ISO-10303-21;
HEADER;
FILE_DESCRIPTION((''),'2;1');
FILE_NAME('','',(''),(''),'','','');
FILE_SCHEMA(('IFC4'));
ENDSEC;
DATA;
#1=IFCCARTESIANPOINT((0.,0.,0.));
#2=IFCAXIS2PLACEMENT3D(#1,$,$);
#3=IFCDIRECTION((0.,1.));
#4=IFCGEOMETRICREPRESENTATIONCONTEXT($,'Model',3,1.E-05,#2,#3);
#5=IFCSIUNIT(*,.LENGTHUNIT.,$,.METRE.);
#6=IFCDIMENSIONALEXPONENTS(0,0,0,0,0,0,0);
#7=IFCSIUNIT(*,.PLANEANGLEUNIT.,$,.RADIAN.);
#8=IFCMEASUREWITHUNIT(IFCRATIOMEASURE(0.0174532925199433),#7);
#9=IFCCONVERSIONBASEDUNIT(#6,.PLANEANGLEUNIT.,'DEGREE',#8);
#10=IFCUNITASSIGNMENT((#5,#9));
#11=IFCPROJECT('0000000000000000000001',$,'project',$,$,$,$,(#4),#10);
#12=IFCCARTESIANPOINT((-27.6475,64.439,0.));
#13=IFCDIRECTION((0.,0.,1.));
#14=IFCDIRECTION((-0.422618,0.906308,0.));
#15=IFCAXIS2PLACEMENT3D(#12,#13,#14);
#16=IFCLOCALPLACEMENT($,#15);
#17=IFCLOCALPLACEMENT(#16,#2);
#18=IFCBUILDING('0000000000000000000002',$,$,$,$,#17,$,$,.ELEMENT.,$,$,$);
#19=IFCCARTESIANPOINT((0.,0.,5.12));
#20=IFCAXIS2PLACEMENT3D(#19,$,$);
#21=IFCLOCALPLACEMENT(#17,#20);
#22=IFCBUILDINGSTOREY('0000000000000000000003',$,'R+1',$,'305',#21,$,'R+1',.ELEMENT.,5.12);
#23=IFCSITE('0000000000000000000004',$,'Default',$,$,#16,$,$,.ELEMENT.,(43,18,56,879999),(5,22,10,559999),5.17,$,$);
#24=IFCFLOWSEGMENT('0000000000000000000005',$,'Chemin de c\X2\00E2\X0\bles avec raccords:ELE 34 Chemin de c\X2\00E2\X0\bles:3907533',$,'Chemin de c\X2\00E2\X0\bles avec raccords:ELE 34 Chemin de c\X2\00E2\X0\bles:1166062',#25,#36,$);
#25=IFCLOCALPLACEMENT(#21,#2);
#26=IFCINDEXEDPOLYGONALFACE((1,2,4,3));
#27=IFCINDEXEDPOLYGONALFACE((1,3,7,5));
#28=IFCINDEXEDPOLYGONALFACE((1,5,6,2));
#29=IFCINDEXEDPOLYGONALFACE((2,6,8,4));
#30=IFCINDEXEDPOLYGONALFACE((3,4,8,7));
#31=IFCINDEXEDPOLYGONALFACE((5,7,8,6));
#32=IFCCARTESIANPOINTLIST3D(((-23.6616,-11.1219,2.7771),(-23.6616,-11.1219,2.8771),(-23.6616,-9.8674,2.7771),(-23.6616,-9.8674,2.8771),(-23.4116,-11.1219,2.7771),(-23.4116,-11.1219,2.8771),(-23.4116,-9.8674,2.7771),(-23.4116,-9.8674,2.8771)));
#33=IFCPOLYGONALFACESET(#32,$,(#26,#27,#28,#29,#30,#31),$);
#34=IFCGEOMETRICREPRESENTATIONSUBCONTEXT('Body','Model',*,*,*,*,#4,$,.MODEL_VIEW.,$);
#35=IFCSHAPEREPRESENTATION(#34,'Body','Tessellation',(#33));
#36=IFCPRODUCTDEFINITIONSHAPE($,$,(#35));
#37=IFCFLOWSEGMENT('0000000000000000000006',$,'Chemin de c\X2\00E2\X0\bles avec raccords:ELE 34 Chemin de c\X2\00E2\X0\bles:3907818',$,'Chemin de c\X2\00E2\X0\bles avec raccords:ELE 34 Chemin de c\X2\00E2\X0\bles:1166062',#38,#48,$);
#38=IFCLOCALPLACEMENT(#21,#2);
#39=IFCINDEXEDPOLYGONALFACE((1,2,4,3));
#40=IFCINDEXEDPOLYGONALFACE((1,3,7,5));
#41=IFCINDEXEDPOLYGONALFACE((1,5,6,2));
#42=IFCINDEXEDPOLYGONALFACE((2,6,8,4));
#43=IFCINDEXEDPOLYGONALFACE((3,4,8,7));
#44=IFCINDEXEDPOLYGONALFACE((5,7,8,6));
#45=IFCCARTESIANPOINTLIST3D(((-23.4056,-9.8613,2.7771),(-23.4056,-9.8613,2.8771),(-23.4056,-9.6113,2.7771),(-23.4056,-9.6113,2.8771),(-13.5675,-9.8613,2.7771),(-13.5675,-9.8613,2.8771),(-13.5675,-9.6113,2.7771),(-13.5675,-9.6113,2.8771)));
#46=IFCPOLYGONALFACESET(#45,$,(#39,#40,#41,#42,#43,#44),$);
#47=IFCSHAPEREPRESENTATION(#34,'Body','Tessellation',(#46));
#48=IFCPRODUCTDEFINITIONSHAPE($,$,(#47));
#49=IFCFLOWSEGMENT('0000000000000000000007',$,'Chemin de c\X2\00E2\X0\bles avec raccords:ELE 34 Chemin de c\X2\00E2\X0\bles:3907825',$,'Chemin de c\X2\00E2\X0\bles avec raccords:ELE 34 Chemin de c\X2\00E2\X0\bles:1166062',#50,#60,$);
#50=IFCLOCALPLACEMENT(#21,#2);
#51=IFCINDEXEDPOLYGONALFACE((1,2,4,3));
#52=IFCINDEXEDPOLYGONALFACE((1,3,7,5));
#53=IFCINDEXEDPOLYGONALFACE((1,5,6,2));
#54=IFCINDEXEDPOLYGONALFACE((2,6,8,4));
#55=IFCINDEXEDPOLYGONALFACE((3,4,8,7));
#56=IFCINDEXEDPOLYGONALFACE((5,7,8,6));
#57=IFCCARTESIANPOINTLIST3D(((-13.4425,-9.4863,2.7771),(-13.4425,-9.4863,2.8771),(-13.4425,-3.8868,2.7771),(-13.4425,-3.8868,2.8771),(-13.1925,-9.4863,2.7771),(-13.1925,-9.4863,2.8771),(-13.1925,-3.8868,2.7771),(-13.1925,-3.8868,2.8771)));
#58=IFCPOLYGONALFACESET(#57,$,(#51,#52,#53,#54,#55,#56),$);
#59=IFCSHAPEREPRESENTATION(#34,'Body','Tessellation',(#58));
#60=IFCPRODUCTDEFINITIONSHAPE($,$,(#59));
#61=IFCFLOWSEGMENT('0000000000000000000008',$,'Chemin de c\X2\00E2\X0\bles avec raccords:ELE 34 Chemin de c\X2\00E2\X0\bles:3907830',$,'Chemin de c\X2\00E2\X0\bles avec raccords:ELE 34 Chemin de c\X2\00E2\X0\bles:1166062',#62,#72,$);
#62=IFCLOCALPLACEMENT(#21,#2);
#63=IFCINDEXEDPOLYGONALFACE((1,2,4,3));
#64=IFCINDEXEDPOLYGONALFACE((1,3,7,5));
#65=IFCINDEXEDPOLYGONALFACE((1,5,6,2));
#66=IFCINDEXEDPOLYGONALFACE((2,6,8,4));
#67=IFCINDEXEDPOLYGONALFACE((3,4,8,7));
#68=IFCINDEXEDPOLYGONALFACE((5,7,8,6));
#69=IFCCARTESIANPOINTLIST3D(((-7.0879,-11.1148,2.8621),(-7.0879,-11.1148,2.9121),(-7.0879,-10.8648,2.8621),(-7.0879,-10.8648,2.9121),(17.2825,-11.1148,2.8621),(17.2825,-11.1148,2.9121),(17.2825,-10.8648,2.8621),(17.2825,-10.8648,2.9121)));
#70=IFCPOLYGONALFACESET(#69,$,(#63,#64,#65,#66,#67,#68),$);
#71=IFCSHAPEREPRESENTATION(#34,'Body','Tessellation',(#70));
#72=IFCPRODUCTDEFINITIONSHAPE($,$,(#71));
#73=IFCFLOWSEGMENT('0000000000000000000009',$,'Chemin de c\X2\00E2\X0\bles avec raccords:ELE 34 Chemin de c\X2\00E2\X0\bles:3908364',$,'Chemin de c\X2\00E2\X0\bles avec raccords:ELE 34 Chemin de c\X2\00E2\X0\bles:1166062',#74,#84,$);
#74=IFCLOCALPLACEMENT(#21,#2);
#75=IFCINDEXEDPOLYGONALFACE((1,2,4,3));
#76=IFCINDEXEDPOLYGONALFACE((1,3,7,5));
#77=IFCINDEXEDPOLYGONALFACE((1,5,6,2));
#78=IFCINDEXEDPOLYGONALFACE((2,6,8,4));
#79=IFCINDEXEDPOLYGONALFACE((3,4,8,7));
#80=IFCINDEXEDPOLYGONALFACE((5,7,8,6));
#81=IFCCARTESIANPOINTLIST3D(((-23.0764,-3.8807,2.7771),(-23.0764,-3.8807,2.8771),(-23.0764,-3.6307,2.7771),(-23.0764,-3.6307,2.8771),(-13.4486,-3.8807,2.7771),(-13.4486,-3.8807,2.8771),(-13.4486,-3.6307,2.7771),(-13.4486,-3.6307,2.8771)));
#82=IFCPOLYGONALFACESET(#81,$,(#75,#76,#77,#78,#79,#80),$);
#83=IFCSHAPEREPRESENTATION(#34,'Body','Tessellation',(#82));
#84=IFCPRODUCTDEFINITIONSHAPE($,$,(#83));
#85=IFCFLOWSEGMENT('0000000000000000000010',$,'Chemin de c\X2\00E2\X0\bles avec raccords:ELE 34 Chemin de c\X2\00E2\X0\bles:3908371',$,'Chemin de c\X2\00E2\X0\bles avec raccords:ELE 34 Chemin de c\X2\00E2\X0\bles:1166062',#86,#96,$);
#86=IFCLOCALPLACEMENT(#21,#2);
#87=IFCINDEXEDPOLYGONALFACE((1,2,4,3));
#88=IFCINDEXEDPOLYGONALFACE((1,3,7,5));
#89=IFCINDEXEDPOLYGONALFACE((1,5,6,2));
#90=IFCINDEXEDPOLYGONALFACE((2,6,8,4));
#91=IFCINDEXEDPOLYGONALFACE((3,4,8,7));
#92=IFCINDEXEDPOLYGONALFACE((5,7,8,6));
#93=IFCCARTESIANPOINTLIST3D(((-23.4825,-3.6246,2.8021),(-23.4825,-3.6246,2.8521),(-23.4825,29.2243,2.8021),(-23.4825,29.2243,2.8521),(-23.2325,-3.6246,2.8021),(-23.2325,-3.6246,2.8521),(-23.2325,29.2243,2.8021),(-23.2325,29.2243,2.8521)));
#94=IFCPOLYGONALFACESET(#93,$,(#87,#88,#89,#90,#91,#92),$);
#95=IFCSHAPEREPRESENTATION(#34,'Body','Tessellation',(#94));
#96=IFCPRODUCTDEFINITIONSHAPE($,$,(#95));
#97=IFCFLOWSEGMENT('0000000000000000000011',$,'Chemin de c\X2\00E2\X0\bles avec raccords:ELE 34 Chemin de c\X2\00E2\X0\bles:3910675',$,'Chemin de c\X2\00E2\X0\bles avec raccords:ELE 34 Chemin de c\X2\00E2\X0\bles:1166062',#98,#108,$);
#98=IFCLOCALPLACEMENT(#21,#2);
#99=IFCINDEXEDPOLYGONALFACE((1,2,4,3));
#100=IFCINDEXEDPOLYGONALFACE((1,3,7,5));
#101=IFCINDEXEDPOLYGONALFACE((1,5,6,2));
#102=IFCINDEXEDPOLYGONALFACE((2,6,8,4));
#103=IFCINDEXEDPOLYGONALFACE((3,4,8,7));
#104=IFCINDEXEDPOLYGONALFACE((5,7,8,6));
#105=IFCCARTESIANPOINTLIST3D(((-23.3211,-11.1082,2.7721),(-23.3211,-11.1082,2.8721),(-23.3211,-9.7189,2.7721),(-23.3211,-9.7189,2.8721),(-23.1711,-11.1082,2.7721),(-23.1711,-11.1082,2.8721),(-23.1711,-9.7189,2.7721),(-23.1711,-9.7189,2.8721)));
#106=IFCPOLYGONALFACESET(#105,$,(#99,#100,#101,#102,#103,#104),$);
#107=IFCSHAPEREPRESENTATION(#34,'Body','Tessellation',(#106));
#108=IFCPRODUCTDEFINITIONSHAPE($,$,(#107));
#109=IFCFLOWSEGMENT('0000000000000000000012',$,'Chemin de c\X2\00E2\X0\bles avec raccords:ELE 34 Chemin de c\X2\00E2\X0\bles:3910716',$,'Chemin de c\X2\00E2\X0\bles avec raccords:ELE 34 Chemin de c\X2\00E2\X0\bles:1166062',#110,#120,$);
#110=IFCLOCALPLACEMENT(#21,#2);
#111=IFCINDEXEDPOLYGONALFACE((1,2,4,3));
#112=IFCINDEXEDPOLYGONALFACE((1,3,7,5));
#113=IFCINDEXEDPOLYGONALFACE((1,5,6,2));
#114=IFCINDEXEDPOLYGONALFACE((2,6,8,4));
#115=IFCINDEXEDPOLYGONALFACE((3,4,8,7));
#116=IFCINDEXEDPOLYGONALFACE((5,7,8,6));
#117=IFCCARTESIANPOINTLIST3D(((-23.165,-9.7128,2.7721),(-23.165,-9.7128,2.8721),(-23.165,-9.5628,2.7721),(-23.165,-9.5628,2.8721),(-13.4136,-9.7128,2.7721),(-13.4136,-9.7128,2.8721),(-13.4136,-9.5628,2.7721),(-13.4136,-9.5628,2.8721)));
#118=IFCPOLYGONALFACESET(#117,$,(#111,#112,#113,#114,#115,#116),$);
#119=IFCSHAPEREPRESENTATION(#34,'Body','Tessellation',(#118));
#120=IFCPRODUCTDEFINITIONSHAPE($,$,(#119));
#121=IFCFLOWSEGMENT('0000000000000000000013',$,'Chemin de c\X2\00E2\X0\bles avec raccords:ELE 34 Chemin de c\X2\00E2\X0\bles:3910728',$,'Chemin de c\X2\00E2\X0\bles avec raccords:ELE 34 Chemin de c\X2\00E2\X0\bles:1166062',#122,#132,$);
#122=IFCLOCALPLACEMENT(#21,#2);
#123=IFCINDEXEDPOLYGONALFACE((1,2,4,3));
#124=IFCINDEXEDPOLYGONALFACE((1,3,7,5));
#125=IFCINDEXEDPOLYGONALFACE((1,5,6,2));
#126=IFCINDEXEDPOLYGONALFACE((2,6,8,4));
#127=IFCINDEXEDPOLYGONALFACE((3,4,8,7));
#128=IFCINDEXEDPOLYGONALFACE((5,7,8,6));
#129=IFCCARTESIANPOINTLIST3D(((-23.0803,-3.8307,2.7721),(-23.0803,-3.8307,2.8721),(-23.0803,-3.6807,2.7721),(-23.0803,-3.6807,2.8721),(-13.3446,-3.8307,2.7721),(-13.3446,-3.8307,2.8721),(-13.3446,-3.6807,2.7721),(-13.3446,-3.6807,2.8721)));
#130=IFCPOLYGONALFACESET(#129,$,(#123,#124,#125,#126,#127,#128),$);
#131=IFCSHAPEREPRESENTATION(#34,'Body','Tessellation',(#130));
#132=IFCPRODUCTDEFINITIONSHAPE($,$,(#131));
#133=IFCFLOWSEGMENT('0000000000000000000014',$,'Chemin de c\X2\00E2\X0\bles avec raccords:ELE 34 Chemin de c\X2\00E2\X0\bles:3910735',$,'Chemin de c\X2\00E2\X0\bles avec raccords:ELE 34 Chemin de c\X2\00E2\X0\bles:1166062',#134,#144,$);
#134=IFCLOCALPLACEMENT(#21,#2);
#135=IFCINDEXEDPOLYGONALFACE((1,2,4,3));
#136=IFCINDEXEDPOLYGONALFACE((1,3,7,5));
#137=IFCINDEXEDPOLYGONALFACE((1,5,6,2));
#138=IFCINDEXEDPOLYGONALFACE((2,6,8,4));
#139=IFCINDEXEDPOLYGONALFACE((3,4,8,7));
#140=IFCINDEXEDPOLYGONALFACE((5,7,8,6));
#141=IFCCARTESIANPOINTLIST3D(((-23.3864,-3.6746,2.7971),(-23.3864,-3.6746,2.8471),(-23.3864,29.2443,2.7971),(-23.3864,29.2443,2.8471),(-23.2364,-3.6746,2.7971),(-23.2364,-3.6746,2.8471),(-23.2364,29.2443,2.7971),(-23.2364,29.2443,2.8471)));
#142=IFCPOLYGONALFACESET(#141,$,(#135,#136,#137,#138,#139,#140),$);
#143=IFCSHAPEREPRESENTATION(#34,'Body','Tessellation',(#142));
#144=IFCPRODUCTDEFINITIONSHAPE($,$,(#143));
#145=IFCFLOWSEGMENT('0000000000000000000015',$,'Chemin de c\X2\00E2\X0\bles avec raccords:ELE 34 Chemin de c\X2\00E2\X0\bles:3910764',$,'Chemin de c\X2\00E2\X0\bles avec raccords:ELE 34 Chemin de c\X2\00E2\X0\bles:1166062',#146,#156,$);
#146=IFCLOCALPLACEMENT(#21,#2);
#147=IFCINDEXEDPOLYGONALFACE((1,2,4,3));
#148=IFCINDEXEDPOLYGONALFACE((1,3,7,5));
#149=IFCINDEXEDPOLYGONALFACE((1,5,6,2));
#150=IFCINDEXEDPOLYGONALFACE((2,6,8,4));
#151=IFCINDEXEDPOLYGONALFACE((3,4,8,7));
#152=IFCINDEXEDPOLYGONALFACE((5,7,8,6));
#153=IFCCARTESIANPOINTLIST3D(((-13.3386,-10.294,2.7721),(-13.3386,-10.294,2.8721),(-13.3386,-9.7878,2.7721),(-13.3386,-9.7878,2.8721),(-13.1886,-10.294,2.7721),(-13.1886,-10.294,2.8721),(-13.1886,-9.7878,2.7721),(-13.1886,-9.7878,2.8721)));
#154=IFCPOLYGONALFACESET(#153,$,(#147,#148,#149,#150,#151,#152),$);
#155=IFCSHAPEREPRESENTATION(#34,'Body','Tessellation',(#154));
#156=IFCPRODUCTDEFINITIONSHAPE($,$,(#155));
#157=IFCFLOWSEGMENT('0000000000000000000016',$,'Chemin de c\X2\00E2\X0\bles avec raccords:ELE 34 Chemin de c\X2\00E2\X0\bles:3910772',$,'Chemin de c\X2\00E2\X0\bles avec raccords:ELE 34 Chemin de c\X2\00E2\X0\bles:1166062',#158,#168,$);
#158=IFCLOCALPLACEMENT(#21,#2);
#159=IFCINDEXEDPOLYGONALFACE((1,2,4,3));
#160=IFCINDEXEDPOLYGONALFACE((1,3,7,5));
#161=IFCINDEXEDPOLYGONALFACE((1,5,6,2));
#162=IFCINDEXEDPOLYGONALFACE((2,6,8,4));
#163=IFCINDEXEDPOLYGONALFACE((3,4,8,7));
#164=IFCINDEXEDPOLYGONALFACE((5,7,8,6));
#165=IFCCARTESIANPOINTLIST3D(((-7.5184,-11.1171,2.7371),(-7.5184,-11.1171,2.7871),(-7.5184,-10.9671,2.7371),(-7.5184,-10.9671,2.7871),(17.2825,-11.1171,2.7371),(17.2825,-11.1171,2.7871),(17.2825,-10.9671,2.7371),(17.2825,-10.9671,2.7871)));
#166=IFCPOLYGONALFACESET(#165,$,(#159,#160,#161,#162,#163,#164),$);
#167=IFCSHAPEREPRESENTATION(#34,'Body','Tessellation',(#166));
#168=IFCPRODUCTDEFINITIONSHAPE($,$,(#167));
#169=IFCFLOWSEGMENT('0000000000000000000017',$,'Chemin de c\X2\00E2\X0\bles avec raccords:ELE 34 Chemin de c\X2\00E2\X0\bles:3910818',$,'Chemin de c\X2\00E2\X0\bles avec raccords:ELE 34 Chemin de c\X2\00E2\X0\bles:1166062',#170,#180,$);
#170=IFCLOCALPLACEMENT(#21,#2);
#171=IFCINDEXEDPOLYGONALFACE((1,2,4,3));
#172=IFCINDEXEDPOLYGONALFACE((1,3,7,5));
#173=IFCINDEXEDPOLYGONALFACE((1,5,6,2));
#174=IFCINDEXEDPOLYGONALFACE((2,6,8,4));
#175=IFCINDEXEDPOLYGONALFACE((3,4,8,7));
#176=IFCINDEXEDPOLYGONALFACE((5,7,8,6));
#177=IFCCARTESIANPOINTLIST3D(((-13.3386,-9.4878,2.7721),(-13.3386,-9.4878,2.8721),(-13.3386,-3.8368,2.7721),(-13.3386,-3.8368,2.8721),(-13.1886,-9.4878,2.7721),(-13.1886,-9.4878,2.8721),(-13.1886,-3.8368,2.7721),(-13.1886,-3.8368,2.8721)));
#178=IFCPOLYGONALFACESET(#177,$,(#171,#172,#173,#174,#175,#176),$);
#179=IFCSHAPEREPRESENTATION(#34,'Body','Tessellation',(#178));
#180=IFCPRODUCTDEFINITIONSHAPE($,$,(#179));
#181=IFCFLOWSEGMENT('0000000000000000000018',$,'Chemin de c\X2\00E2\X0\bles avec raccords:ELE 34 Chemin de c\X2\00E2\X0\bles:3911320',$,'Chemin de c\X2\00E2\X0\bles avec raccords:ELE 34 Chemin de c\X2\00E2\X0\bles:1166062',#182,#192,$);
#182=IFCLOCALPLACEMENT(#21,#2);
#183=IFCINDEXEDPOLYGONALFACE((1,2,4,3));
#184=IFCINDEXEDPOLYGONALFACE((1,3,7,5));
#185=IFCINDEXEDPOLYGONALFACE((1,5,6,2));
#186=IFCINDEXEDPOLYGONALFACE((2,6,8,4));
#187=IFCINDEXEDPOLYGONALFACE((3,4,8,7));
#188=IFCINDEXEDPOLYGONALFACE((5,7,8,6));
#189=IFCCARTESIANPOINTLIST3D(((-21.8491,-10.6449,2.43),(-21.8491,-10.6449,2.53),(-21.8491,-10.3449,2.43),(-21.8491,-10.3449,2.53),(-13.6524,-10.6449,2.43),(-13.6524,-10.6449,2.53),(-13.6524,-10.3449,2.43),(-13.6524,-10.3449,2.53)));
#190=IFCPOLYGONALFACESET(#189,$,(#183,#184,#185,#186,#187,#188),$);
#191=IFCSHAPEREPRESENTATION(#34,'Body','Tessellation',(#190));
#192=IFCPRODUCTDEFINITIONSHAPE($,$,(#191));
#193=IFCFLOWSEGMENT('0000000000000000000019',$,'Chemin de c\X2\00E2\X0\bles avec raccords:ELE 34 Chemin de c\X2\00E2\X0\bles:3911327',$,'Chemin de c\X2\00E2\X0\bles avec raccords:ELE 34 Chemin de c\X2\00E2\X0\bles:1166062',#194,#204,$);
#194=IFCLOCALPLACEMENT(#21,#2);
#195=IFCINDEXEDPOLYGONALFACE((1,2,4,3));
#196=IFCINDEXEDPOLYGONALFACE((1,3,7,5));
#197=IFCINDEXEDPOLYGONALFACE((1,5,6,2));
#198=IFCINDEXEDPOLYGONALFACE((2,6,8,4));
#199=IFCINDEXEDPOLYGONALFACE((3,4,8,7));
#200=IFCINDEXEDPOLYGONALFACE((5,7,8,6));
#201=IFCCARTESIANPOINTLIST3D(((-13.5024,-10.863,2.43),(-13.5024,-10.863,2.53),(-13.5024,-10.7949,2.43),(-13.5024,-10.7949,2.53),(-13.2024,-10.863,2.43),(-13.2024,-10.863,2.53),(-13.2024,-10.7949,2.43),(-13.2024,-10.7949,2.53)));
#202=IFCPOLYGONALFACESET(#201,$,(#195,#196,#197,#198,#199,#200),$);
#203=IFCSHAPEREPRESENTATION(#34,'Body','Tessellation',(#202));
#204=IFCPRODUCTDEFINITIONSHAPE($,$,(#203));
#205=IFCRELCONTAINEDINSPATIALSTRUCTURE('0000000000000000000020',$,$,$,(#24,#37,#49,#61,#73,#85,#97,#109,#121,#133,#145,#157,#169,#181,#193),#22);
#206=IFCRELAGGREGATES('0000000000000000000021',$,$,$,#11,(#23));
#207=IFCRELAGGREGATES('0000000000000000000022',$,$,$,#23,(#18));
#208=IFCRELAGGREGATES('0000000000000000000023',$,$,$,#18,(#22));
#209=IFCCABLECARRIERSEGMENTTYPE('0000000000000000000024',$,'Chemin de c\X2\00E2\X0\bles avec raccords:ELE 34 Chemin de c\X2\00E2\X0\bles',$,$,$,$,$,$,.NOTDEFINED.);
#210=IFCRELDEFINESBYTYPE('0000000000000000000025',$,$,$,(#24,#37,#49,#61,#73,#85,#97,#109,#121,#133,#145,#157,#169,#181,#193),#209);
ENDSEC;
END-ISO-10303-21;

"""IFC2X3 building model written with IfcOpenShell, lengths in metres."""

from ifc_helpers import new_model, entity, si_unit, converted_unit, direction, frame, frame_2d, origin, origin_2d_with_axis, place, context, subcontext, project, spatial, polyline, rectangle, outline, extrude, type_object, element, save


model = new_model("IFC2X3")

# Units and contexts
model_context = context("Model", 3, precision=1e-05, world=origin(), true_north=direction((0.0, 1.0)))
body_context = subcontext(model_context, "Body", "Model", "MODEL_VIEW")
ifc_project = project(units=[si_unit("LENGTHUNIT", "METRE"), converted_unit("PLANEANGLEUNIT", "DEGREE", entity("IfcRatioMeasure", 0.0174532925199433), si_unit("PLANEANGLEUNIT", "RADIAN"), dimensions=[0, 0, 0, 0, 0, 0, 0])], contexts=[model_context])

# Site, building, storey
site_placement = place(None, frame((-27.6475, 64.439, 0.0), z_axis=(0.0, 0.0, 1.0), x_axis=(-0.422618, 0.906308, 0.0)))
site = spatial("IfcSite", under=ifc_project, at=site_placement, Name="Default", CompositionType="ELEMENT", RefLatitude=(43, 18, 56, 879999), RefLongitude=(5, 22, 10, 559999), RefElevation=5.17)
building_placement = place(site_placement, origin())
building = spatial("IfcBuilding", under=site, at=building_placement, CompositionType="ELEMENT")
storey_placement = place(building_placement, frame((0.0, 0.0, 5.12)))
storey = spatial("IfcBuildingStorey", under=building, at=storey_placement, Name="R+1", ObjectType="305", LongName="R+1", CompositionType="ELEMENT", Elevation=5.12)

# Flow segments
cable_carrier_segment_type = type_object("IfcCableCarrierSegmentType", Name="Chemin de câbles avec raccords:ELE 34 Chemin de câbles", PredefinedType="NOTDEFINED")
flow_segment_1_placement = place(storey_placement, origin())
element("IfcFlowSegment", 1, at=flow_segment_1_placement, inside=storey, type_object=cable_carrier_segment_type, Name="Chemin de câbles avec raccords:ELE 34 Chemin de câbles:3907533", ObjectType="Chemin de câbles avec raccords:ELE 34 Chemin de câbles:1166062", context=body_context, shape_type="SweptSolid", body=[
    extrude(outline(polyline([(-0.6273, -0.125), (0.6273, -0.125), (0.6273, 0.125), (-0.6273, 0.125), (-0.6273, -0.125)])), frame((-23.5366, -10.4947, 2.7771), z_axis=(0.0, 0.0, 1.0), x_axis=(0.0, -1.0, 0.0)), (0.0, 0.0, 1.0), 0.1),
])
flow_segment_2_placement = place(storey_placement, origin())
element("IfcFlowSegment", 2, at=flow_segment_2_placement, inside=storey, type_object=cable_carrier_segment_type, Name="Chemin de câbles avec raccords:ELE 34 Chemin de câbles:3907818", ObjectType="Chemin de câbles avec raccords:ELE 34 Chemin de câbles:1166062", context=body_context, shape_type="SweptSolid", body=[
    extrude(rectangle(XDim=9.8381, YDim=0.25, at=origin_2d_with_axis()), frame((-18.4865, -9.7363, 2.7771), z_axis=(0.0, 0.0, 1.0), x_axis=(-1.0, 0.0, 0.0)), (0.0, 0.0, 1.0), 0.1),
])
flow_segment_3_placement = place(storey_placement, origin())
element("IfcFlowSegment", 3, at=flow_segment_3_placement, inside=storey, type_object=cable_carrier_segment_type, Name="Chemin de câbles avec raccords:ELE 34 Chemin de câbles:3907825", ObjectType="Chemin de câbles avec raccords:ELE 34 Chemin de câbles:1166062", context=body_context, shape_type="SweptSolid", body=[
    extrude(rectangle(XDim=5.5995, YDim=0.25, at=frame_2d((0.0, 0.0), x_axis=(1.0, 0.0))), frame((-13.3175, -6.6865, 2.7771), z_axis=(0.0, 0.0, 1.0), x_axis=(0.0, 1.0, 0.0)), (0.0, 0.0, 1.0), 0.1),
])
flow_segment_4_placement = place(storey_placement, origin())
element("IfcFlowSegment", 4, at=flow_segment_4_placement, inside=storey, type_object=cable_carrier_segment_type, Name="Chemin de câbles avec raccords:ELE 34 Chemin de câbles:3907830", ObjectType="Chemin de câbles avec raccords:ELE 34 Chemin de câbles:1166062", context=body_context, shape_type="SweptSolid", body=[
    extrude(rectangle(XDim=24.3704, YDim=0.25, at=frame_2d((0.0, 0.0), x_axis=(1.0, 0.0))), frame((5.0973, -10.9898, 2.8621)), (0.0, 0.0, 1.0), 0.05),
])
flow_segment_5_placement = place(storey_placement, origin())
element("IfcFlowSegment", 5, at=flow_segment_5_placement, inside=storey, type_object=cable_carrier_segment_type, Name="Chemin de câbles avec raccords:ELE 34 Chemin de câbles:3908364", ObjectType="Chemin de câbles avec raccords:ELE 34 Chemin de câbles:1166062", context=body_context, shape_type="SweptSolid", body=[
    extrude(rectangle(XDim=9.6278, YDim=0.25, at=origin_2d_with_axis()), frame((-18.2625, -3.7557, 2.7771), z_axis=(-0.000002, 0.0, 1.0), x_axis=(-1.0, 0.0, -0.000002)), (0.0, 0.0, 1.0), 0.1),
])
flow_segment_6_placement = place(storey_placement, origin())
element("IfcFlowSegment", 6, at=flow_segment_6_placement, inside=storey, type_object=cable_carrier_segment_type, Name="Chemin de câbles avec raccords:ELE 34 Chemin de câbles:3908371", ObjectType="Chemin de câbles avec raccords:ELE 34 Chemin de câbles:1166062", context=body_context, shape_type="SweptSolid", body=[
    extrude(rectangle(XDim=32.8489, YDim=0.25, at=origin_2d_with_axis()), frame((-23.3575, 12.7998, 2.8021), z_axis=(-0.000002, 0.0, 1.0), x_axis=(0.0, 1.0, 0.0)), (0.0, 0.0, 1.0), 0.05),
])
flow_segment_7_placement = place(storey_placement, origin())
element("IfcFlowSegment", 7, at=flow_segment_7_placement, inside=storey, type_object=cable_carrier_segment_type, Name="Chemin de câbles avec raccords:ELE 34 Chemin de câbles:3910675", ObjectType="Chemin de câbles avec raccords:ELE 34 Chemin de câbles:1166062", context=body_context, shape_type="SweptSolid", body=[
    extrude(rectangle(XDim=0.1, YDim=0.15, at=frame_2d((0.0, 0.0), x_axis=(0.0, 1.0))), frame((-23.2461, -11.1082, 2.8221), z_axis=(0.000045, 1.0, -0.000014), x_axis=(1.0, -0.000045, 0.0)), (-0.000045, -0.000013, 1.0), 1.3893),
])
flow_segment_8_placement = place(storey_placement, origin())
element("IfcFlowSegment", 8, at=flow_segment_8_placement, inside=storey, type_object=cable_carrier_segment_type, Name="Chemin de câbles avec raccords:ELE 34 Chemin de câbles:3910716", ObjectType="Chemin de câbles avec raccords:ELE 34 Chemin de câbles:1166062", context=body_context, shape_type="SweptSolid", body=[
    extrude(rectangle(XDim=9.7515, YDim=0.15, at=frame_2d((0.0, 0.0), x_axis=(1.0, 0.0))), frame((-18.2893, -9.6378, 2.7721), z_axis=(0.0, 0.000001, 1.0), x_axis=(-1.0, 0.0, 0.0)), (0.0, 0.0, 1.0), 0.1),
])
flow_segment_9_placement = place(storey_placement, origin())
element("IfcFlowSegment", 9, at=flow_segment_9_placement, inside=storey, type_object=cable_carrier_segment_type, Name="Chemin de câbles avec raccords:ELE 34 Chemin de câbles:3910728", ObjectType="Chemin de câbles avec raccords:ELE 34 Chemin de câbles:1166062", context=body_context, shape_type="SweptSolid", body=[
    extrude(rectangle(XDim=9.7357, YDim=0.15, at=origin_2d_with_axis()), frame((-18.2125, -3.7557, 2.7721), z_axis=(0.0, 0.0, 1.0), x_axis=(-1.0, 0.0, 0.0)), (0.0, 0.0, 1.0), 0.1),
])
flow_segment_10_placement = place(storey_placement, origin())
element("IfcFlowSegment", 10, at=flow_segment_10_placement, inside=storey, type_object=cable_carrier_segment_type, Name="Chemin de câbles avec raccords:ELE 34 Chemin de câbles:3910735", ObjectType="Chemin de câbles avec raccords:ELE 34 Chemin de câbles:1166062", context=body_context, shape_type="SweptSolid", body=[
    extrude(rectangle(XDim=32.9189, YDim=0.15, at=origin_2d_with_axis()), frame((-23.3114, 12.7848, 2.7971), z_axis=(0.0, 0.0, 1.0), x_axis=(0.0, 1.0, 0.0)), (0.0, 0.0, 1.0), 0.05),
])
flow_segment_11_placement = place(storey_placement, origin())
element("IfcFlowSegment", 11, at=flow_segment_11_placement, inside=storey, type_object=cable_carrier_segment_type, Name="Chemin de câbles avec raccords:ELE 34 Chemin de câbles:3910764", ObjectType="Chemin de câbles avec raccords:ELE 34 Chemin de câbles:1166062", context=body_context, shape_type="SweptSolid", body=[
    extrude(rectangle(XDim=0.5062, YDim=0.15, at=origin_2d_with_axis()), frame((-13.2636, -10.0409, 2.7721), z_axis=(0.0, 0.0, 1.0), x_axis=(0.0, -1.0, 0.0)), (0.0, 0.0, 1.0), 0.1),
])
flow_segment_12_placement = place(storey_placement, origin())
element("IfcFlowSegment", 12, at=flow_segment_12_placement, inside=storey, type_object=cable_carrier_segment_type, Name="Chemin de câbles avec raccords:ELE 34 Chemin de câbles:3910772", ObjectType="Chemin de câbles avec raccords:ELE 34 Chemin de câbles:1166062", context=body_context, shape_type="SweptSolid", body=[
    extrude(rectangle(XDim=24.8009, YDim=0.15, at=origin_2d_with_axis()), frame((4.8821, -11.0421, 2.7371)), (0.0, 0.0, 1.0), 0.05),
])
flow_segment_13_placement = place(storey_placement, origin())
element("IfcFlowSegment", 13, at=flow_segment_13_placement, inside=storey, type_object=cable_carrier_segment_type, Name="Chemin de câbles avec raccords:ELE 34 Chemin de câbles:3910818", ObjectType="Chemin de câbles avec raccords:ELE 34 Chemin de câbles:1166062", context=body_context, shape_type="SweptSolid", body=[
    extrude(rectangle(XDim=5.6511, YDim=0.15, at=origin_2d_with_axis()), frame((-13.2636, -6.6623, 2.7721), z_axis=(0.0, 0.0, 1.0), x_axis=(0.0, -1.0, 0.0)), (0.0, 0.0, 1.0), 0.1),
])
flow_segment_14_placement = place(storey_placement, origin())
element("IfcFlowSegment", 14, at=flow_segment_14_placement, inside=storey, type_object=cable_carrier_segment_type, Name="Chemin de câbles avec raccords:ELE 34 Chemin de câbles:3911320", ObjectType="Chemin de câbles avec raccords:ELE 34 Chemin de câbles:1166062", context=body_context, shape_type="SweptSolid", body=[
    extrude(rectangle(XDim=8.1968, YDim=0.3, at=frame_2d((0.0, 0.0), x_axis=(1.0, 0.0))), frame((-17.7508, -10.4949, 2.43), z_axis=(0.0, 0.0, 1.0), x_axis=(-1.0, 0.0, 0.0)), (0.0, 0.0, 1.0), 0.1),
])
flow_segment_15_placement = place(storey_placement, origin())
element("IfcFlowSegment", 15, at=flow_segment_15_placement, inside=storey, type_object=cable_carrier_segment_type, Name="Chemin de câbles avec raccords:ELE 34 Chemin de câbles:3911327", ObjectType="Chemin de câbles avec raccords:ELE 34 Chemin de câbles:1166062", context=body_context, shape_type="SweptSolid", body=[
    extrude(rectangle(XDim=0.0681, YDim=0.3, at=origin_2d_with_axis()), frame((-13.3524, -10.829, 2.43), z_axis=(0.0, 0.0, 1.0), x_axis=(0.0, -1.0, 0.0)), (0.0, 0.0, 1.0), 0.1),
])

save(model, "model.ifc")
